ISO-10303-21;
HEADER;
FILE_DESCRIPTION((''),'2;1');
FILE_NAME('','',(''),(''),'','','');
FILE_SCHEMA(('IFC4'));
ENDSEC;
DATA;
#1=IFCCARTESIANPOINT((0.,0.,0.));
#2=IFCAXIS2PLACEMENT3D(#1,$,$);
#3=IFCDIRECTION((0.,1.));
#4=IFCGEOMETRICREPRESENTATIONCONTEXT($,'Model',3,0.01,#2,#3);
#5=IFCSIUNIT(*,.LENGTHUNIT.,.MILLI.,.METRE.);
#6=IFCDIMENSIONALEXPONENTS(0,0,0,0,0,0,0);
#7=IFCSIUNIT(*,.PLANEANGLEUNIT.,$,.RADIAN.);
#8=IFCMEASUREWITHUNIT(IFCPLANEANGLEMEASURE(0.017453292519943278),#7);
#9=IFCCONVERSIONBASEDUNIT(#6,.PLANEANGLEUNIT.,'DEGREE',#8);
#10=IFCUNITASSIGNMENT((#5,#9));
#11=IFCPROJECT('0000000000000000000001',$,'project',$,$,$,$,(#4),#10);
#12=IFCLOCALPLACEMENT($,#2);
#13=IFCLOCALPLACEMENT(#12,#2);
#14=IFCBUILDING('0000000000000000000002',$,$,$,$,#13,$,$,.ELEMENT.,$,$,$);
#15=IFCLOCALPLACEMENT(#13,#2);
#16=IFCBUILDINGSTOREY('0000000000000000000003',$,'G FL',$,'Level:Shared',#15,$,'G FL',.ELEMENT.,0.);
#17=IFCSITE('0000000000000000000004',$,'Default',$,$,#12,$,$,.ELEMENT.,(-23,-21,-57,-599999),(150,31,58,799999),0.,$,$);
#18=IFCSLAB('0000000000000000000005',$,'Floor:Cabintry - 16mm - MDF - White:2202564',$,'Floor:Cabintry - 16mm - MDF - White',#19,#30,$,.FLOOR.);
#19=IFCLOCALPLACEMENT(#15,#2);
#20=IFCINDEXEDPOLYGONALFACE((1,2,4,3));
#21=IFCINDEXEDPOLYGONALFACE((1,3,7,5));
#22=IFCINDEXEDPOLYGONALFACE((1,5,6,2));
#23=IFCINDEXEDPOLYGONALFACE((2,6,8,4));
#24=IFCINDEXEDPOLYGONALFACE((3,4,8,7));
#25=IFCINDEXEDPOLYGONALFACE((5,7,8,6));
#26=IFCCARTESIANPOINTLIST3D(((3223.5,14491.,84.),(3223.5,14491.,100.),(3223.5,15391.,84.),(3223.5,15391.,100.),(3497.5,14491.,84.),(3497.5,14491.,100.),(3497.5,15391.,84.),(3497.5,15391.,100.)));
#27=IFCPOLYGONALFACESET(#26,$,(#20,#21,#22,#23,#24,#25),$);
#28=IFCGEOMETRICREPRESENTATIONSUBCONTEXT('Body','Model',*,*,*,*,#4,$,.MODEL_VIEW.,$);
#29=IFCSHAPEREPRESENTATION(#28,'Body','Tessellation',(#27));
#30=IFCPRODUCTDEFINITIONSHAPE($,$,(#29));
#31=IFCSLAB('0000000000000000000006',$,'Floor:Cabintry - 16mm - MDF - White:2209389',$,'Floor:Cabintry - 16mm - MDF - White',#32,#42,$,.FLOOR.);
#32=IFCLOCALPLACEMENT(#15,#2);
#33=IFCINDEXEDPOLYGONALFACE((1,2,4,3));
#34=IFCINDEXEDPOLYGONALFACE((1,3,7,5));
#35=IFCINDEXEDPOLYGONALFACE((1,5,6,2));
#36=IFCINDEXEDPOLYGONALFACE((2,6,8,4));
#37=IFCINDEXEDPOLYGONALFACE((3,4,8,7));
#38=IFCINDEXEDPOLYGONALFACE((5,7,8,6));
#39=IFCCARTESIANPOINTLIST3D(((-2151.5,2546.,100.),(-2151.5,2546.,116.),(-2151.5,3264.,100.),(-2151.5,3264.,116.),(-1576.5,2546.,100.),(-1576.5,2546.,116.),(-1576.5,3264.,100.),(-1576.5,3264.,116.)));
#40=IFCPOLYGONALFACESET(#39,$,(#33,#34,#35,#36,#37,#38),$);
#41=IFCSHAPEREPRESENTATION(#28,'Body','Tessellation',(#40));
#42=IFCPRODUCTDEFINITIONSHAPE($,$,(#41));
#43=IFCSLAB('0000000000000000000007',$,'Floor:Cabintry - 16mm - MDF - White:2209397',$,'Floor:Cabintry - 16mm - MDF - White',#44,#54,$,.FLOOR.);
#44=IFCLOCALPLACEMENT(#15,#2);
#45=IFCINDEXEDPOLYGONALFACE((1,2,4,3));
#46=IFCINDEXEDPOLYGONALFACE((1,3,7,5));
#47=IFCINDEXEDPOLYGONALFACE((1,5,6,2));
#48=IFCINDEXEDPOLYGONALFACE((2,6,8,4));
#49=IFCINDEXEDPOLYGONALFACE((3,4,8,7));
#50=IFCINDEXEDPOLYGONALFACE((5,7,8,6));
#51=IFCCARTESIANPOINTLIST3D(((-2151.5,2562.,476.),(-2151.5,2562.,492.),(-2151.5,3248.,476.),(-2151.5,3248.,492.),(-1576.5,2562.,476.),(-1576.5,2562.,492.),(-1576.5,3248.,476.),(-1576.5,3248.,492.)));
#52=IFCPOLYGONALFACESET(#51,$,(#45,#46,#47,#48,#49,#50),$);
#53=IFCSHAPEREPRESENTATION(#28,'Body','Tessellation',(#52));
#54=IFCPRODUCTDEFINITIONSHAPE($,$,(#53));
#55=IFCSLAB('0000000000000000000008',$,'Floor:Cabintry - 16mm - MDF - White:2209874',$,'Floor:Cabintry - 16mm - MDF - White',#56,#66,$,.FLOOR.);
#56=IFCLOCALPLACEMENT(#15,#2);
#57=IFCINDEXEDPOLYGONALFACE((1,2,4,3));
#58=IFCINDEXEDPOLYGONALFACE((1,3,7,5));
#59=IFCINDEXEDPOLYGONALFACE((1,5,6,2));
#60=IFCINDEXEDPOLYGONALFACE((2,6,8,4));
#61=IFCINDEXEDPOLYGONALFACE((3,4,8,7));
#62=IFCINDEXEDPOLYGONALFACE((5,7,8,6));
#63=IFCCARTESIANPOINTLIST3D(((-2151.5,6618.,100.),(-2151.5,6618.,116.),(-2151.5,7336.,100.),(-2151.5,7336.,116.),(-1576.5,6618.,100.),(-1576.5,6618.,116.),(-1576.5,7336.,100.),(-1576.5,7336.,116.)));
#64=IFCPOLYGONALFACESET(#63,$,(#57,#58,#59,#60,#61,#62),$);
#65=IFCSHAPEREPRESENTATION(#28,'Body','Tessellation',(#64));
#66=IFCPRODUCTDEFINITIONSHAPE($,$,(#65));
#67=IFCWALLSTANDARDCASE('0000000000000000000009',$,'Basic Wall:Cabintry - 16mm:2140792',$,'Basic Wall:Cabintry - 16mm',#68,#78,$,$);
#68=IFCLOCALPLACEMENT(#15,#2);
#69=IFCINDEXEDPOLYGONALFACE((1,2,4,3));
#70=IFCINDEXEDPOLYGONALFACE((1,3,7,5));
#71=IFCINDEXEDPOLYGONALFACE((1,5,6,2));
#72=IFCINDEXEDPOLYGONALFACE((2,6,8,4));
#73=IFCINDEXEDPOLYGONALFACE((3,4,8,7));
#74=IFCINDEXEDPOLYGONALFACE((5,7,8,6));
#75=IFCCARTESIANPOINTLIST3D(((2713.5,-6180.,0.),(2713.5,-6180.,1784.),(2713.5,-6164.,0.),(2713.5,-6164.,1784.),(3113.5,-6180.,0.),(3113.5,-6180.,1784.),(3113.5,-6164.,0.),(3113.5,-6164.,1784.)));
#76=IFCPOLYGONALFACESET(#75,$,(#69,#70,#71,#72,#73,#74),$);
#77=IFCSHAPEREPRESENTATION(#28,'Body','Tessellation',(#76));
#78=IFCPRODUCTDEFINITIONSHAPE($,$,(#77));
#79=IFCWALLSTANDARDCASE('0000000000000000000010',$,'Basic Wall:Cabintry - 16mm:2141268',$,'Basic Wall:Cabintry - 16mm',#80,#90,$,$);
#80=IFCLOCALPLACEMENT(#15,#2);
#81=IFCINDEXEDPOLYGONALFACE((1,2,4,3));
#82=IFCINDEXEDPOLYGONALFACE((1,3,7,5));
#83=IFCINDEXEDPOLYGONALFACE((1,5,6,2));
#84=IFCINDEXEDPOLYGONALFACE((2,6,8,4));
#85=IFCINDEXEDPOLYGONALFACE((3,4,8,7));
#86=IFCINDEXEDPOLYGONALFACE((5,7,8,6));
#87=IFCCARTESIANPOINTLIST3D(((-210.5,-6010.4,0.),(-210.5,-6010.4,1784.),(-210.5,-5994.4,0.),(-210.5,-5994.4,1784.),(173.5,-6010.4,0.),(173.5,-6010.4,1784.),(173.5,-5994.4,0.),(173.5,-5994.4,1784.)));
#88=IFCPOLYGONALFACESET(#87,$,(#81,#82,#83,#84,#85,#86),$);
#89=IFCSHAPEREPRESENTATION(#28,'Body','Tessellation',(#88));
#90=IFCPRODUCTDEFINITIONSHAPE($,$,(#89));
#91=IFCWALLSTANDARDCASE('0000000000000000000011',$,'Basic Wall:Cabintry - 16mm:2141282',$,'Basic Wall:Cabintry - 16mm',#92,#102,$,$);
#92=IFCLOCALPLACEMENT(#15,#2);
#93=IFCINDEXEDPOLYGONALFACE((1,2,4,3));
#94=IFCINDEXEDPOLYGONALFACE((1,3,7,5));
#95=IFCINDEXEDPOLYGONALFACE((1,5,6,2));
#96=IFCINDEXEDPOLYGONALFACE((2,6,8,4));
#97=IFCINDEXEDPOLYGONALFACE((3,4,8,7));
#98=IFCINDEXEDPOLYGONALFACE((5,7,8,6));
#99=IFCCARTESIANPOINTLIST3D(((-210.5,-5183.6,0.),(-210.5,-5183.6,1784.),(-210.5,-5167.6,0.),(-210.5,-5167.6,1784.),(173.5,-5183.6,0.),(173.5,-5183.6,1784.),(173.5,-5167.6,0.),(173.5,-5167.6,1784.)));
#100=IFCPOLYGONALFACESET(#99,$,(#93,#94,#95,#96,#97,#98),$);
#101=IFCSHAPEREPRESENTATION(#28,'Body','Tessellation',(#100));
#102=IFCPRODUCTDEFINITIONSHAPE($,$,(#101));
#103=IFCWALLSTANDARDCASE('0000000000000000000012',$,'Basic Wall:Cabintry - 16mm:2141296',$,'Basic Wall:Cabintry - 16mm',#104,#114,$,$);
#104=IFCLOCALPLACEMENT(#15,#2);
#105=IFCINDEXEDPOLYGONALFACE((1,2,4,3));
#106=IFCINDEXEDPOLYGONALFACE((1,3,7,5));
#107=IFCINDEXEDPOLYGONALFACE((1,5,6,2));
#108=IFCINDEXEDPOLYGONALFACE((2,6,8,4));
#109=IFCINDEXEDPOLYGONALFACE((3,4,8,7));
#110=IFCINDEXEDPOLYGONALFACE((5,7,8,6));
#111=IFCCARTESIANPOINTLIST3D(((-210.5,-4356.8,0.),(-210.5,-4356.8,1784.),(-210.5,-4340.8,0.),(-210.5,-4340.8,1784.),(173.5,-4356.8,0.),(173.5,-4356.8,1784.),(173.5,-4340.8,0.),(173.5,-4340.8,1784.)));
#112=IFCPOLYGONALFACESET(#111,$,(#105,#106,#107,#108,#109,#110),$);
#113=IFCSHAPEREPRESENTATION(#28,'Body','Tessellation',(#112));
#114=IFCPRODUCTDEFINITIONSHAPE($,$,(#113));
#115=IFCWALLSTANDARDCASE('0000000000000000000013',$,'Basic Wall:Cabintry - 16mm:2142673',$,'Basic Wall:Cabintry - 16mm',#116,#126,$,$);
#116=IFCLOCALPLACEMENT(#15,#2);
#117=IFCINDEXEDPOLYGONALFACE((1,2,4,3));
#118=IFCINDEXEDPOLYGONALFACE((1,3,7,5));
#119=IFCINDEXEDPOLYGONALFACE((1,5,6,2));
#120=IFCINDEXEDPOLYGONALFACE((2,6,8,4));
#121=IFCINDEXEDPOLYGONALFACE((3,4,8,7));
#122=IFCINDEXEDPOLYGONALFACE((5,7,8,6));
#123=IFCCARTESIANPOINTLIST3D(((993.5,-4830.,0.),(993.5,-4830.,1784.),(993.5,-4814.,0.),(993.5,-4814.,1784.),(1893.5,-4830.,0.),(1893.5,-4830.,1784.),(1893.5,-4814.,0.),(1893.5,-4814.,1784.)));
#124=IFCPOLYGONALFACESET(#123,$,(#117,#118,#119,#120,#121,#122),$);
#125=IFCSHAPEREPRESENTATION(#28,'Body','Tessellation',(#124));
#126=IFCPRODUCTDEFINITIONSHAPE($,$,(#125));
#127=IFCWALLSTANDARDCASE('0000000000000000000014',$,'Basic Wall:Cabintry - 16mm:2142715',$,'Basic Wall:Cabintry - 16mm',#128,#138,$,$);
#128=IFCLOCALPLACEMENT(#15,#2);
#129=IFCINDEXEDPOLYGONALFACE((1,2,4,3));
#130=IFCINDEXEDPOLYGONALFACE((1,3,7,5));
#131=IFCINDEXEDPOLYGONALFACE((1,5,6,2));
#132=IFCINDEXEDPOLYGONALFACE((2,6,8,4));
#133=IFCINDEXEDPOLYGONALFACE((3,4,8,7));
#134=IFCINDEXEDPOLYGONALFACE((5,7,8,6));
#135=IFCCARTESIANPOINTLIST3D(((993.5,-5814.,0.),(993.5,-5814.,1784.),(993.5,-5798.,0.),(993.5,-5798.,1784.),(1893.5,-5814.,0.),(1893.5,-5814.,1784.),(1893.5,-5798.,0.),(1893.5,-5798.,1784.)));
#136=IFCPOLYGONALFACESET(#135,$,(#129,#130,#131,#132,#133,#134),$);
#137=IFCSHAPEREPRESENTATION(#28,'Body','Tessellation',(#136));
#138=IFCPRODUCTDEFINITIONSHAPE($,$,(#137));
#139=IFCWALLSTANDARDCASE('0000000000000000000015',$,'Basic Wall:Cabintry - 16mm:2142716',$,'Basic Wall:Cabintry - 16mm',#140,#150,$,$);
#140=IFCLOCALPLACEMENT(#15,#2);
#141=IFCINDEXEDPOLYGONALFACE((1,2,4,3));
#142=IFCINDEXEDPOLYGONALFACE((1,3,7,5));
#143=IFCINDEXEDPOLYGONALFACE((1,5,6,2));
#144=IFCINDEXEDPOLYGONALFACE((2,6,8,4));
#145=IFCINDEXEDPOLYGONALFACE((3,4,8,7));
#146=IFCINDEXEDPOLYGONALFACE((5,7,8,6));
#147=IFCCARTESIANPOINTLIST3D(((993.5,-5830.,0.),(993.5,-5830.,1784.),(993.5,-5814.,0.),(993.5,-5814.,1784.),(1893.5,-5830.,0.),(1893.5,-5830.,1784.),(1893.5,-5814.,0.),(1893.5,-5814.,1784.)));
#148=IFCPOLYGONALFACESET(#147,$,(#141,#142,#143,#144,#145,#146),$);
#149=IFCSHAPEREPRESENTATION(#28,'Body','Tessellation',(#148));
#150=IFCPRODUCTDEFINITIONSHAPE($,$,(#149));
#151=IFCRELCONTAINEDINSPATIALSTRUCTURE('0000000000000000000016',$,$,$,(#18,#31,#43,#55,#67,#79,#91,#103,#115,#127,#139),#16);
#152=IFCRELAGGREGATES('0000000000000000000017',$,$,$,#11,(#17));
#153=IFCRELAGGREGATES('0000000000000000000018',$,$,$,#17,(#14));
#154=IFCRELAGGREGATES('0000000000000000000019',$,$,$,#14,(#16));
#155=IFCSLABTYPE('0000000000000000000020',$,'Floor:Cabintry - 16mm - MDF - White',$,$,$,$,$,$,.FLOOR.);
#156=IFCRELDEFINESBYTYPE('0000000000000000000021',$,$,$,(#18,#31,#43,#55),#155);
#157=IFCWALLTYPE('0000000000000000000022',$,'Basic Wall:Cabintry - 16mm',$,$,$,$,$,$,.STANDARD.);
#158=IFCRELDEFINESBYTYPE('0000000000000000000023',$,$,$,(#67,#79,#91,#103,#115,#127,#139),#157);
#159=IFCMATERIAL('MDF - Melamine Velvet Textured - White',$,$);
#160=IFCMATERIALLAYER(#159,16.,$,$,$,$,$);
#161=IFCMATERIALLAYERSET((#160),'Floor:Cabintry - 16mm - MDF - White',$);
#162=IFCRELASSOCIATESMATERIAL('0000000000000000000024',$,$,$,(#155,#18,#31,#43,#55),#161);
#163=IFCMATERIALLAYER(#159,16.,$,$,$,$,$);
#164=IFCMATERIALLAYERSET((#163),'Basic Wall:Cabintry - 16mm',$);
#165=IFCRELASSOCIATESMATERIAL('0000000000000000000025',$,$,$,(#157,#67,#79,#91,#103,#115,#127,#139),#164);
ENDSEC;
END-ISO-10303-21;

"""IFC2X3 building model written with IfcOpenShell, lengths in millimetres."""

from ifc_helpers import new_model, entity, si_unit, converted_unit, direction, frame, frame_2d, origin, origin_2d_with_axis, place, context, subcontext, project, spatial, polyline, rectangle, extrude, clip, bounded_halfspace, material, layer, layer_set, layer_usage, type_object, element, save


model = new_model("IFC2X3")

# Units and contexts
model_context = context("Model", 3, precision=0.01, world=origin(), true_north=direction((0.0, 1.0)))
body_context = subcontext(model_context, "Body", "Model", "MODEL_VIEW")
ifc_project = project(units=[si_unit("LENGTHUNIT", "METRE", prefix="MILLI"), converted_unit("PLANEANGLEUNIT", "DEGREE", entity("IfcPlaneAngleMeasure", 0.017453292519943278), si_unit("PLANEANGLEUNIT", "RADIAN"), dimensions=[0, 0, 0, 0, 0, 0, 0])], contexts=[model_context])

# Site, building, storey
site_placement = place(None, origin())
site = spatial("IfcSite", under=ifc_project, at=site_placement, Name="Default", CompositionType="ELEMENT", RefLatitude=(-23, -21, -57, -599999), RefLongitude=(150, 31, 58, 799999), RefElevation=0.0)
building_placement = place(site_placement, origin())
building = spatial("IfcBuilding", under=site, at=building_placement, CompositionType="ELEMENT")
storey_placement = place(building_placement, origin())
storey = spatial("IfcBuildingStorey", under=building, at=storey_placement, Name="G FL", ObjectType="Level:Shared", LongName="G FL", CompositionType="ELEMENT", Elevation=0.0)

# Slabs
ifc_material_1 = material(Name="MDF - Melamine Velvet Textured - White")
ifc_layer_1 = layer(ifc_material_1, 16.0)
ifc_layer_set_1 = layer_set([ifc_layer_1], Name="Floor:Cabintry - 16mm - MDF - White")
slab_type_1 = type_object("IfcSlabType", Name="Floor:Cabintry - 16mm - MDF - White", PredefinedType="FLOOR", material=ifc_layer_set_1)
ifc_layer_usage_1 = layer_usage(ifc_layer_set_1, "AXIS3", "POSITIVE", 0.0)
slab_1_placement = place(storey_placement, origin())
element("IfcSlab", 1, at=slab_1_placement, inside=storey, type_object=slab_type_1, material=ifc_layer_usage_1, Name="Floor:Cabintry - 16mm - MDF - White:2202564", ObjectType="Floor:Cabintry - 16mm - MDF - White", PredefinedType="FLOOR", context=body_context, shape_type="SweptSolid", body=[
    extrude(rectangle(XDim=900.0, YDim=274.0, at=origin_2d_with_axis()), frame((3360.5, 14941.0, 100.0), z_axis=(0.0, 0.0, -1.0), x_axis=(0.0, 1.0, 0.0)), (0.0, 0.0, 1.0), 16.0),
])
ifc_layer_usage_2 = layer_usage(ifc_layer_set_1, "AXIS3", "POSITIVE", 0.0)
slab_2_placement = place(storey_placement, origin())
element("IfcSlab", 2, at=slab_2_placement, inside=storey, type_object=slab_type_1, material=ifc_layer_usage_2, Name="Floor:Cabintry - 16mm - MDF - White:2209389", ObjectType="Floor:Cabintry - 16mm - MDF - White", PredefinedType="FLOOR", context=body_context, shape_type="SweptSolid", body=[
    extrude(rectangle(XDim=718.0, YDim=575.0, at=frame_2d((0.0, 0.0), x_axis=(1.0, 0.0))), frame((-1864.0, 2905.0, 116.0), z_axis=(0.0, 0.0, -1.0), x_axis=(0.0, 1.0, 0.0)), (0.0, 0.0, 1.0), 16.0),
])
ifc_layer_usage_3 = layer_usage(ifc_layer_set_1, "AXIS3", "POSITIVE", 0.0)
slab_3_placement = place(storey_placement, origin())
element("IfcSlab", 3, at=slab_3_placement, inside=storey, type_object=slab_type_1, material=ifc_layer_usage_3, Name="Floor:Cabintry - 16mm - MDF - White:2209397", ObjectType="Floor:Cabintry - 16mm - MDF - White", PredefinedType="FLOOR", context=body_context, shape_type="SweptSolid", body=[
    extrude(rectangle(XDim=686.0, YDim=575.0, at=frame_2d((0.0, 0.0), x_axis=(1.0, 0.0))), frame((-1864.0, 2905.0, 492.0), z_axis=(0.0, 0.0, -1.0), x_axis=(0.0, 1.0, 0.0)), (0.0, 0.0, 1.0), 16.0),
])
ifc_layer_usage_4 = layer_usage(ifc_layer_set_1, "AXIS3", "POSITIVE", 0.0)
slab_4_placement = place(storey_placement, origin())
element("IfcSlab", 4, at=slab_4_placement, inside=storey, type_object=slab_type_1, material=ifc_layer_usage_4, Name="Floor:Cabintry - 16mm - MDF - White:2209874", ObjectType="Floor:Cabintry - 16mm - MDF - White", PredefinedType="FLOOR", context=body_context, shape_type="SweptSolid", body=[
    extrude(rectangle(XDim=718.0, YDim=575.0, at=frame_2d((0.0, 0.0), x_axis=(1.0, 0.0))), frame((-1864.0, 6977.0, 116.0), z_axis=(0.0, 0.0, -1.0), x_axis=(0.0, 1.0, 0.0)), (0.0, 0.0, 1.0), 16.0),
])

# Walls
ifc_layer_2 = layer(ifc_material_1, 16.0)
ifc_layer_set_2 = layer_set([ifc_layer_2], Name="Basic Wall:Cabintry - 16mm")
ifc_layer_usage_5 = layer_usage(ifc_layer_set_2, "AXIS2", "NEGATIVE", 8.0)
wall_type = type_object("IfcWallType", Name="Basic Wall:Cabintry - 16mm", PredefinedType="STANDARD", material=ifc_layer_set_2)
wall_1_placement = place(storey_placement, frame((2713.5, -6172.0, 0.0)))
element("IfcWallStandardCase", 5, at=wall_1_placement, inside=storey, type_object=wall_type, material=ifc_layer_usage_5, Name="Basic Wall:Cabintry - 16mm:2140792", ObjectType="Basic Wall:Cabintry - 16mm", context=body_context, shape_type="Clipping", body=[
    clip(extrude(rectangle(XDim=400.0, YDim=16.0, at=frame_2d((200.0, 0.0), x_axis=(-1.0, 0.0))), origin(), (0.0, 0.0, 1.0), 1784.0), bounded_halfspace(frame((0.0, -8.0, 1784.0), z_axis=(0.0, 0.0, -1.0), x_axis=(1.0, 0.0, 0.0)), True, frame((0.0, -8.0, 1784.0)), polyline([(0.0, 0.0), (384.0, 0.0), (400.0, 0.0), (400.0, 16.0), (0.0, 16.0), (0.0, 0.0)]))),
])
ifc_layer_usage_6 = layer_usage(ifc_layer_set_2, "AXIS2", "NEGATIVE", 8.0)
wall_2_placement = place(storey_placement, frame((173.5, -6002.4, 0.0), z_axis=(0.0, 0.0, 1.0), x_axis=(-1.0, 0.0, 0.0)))
element("IfcWallStandardCase", 6, at=wall_2_placement, inside=storey, type_object=wall_type, material=ifc_layer_usage_6, Name="Basic Wall:Cabintry - 16mm:2141268", ObjectType="Basic Wall:Cabintry - 16mm", context=body_context, shape_type="Clipping", body=[
    clip(extrude(rectangle(XDim=384.0, YDim=16.0, at=frame_2d((192.0, 0.0), x_axis=(-1.0, 0.0))), origin(), (0.0, 0.0, 1.0), 1784.0), bounded_halfspace(frame((0.0, -8.0, 1784.0), z_axis=(0.0, 0.0, -1.0), x_axis=(-1.0, 0.0, 0.0)), True, frame((0.0, -8.0, 1784.0)), polyline([(0.0, 0.0), (384.0, 0.0), (384.0, 16.0), (0.0, 16.0), (0.0, 0.0)]))),
])
ifc_layer_usage_7 = layer_usage(ifc_layer_set_2, "AXIS2", "NEGATIVE", 8.0)
wall_3_placement = place(storey_placement, frame((173.5, -5175.6, 0.0), z_axis=(0.0, 0.0, 1.0), x_axis=(-1.0, 0.0, 0.0)))
element("IfcWallStandardCase", 7, at=wall_3_placement, inside=storey, type_object=wall_type, material=ifc_layer_usage_7, Name="Basic Wall:Cabintry - 16mm:2141282", ObjectType="Basic Wall:Cabintry - 16mm", context=body_context, shape_type="Clipping", body=[
    clip(extrude(rectangle(XDim=384.0, YDim=16.0, at=frame_2d((192.0, 0.0), x_axis=(-1.0, 0.0))), origin(), (0.0, 0.0, 1.0), 1784.0), bounded_halfspace(frame((0.0, -8.0, 1784.0), z_axis=(0.0, 0.0, -1.0), x_axis=(-1.0, 0.0, 0.0)), True, frame((0.0, -8.0, 1784.0)), polyline([(0.0, 0.0), (384.0, 0.0), (384.0, 16.0), (0.0, 16.0), (0.0, 0.0)]))),
])
ifc_layer_usage_8 = layer_usage(ifc_layer_set_2, "AXIS2", "NEGATIVE", 8.0)
wall_4_placement = place(storey_placement, frame((173.5, -4348.8, 0.0), z_axis=(0.0, 0.0, 1.0), x_axis=(-1.0, 0.0, 0.0)))
element("IfcWallStandardCase", 8, at=wall_4_placement, inside=storey, type_object=wall_type, material=ifc_layer_usage_8, Name="Basic Wall:Cabintry - 16mm:2141296", ObjectType="Basic Wall:Cabintry - 16mm", context=body_context, shape_type="Clipping", body=[
    clip(extrude(rectangle(XDim=384.0, YDim=16.0, at=frame_2d((192.0, 0.0), x_axis=(-1.0, 0.0))), origin(), (0.0, 0.0, 1.0), 1784.0), bounded_halfspace(frame((0.0, -8.0, 1784.0), z_axis=(0.0, 0.0, -1.0), x_axis=(-1.0, 0.0, 0.0)), True, frame((0.0, -8.0, 1784.0)), polyline([(0.0, 0.0), (384.0, 0.0), (384.0, 16.0), (0.0, 16.0), (0.0, 0.0)]))),
])
ifc_layer_usage_9 = layer_usage(ifc_layer_set_2, "AXIS2", "NEGATIVE", 8.0)
wall_5_placement = place(storey_placement, frame((993.5, -4822.0, 0.0)))
element("IfcWallStandardCase", 9, at=wall_5_placement, inside=storey, type_object=wall_type, material=ifc_layer_usage_9, Name="Basic Wall:Cabintry - 16mm:2142673", ObjectType="Basic Wall:Cabintry - 16mm", context=body_context, shape_type="SweptSolid", body=[
    extrude(rectangle(XDim=900.0, YDim=16.0, at=frame_2d((450.0, 0.0), x_axis=(-1.0, 0.0))), origin(), (0.0, 0.0, 1.0), 1784.0),
])
ifc_layer_usage_10 = layer_usage(ifc_layer_set_2, "AXIS2", "NEGATIVE", 8.0)
wall_6_placement = place(storey_placement, frame((993.5, -5806.0, 0.0)))
element("IfcWallStandardCase", 10, at=wall_6_placement, inside=storey, type_object=wall_type, material=ifc_layer_usage_10, Name="Basic Wall:Cabintry - 16mm:2142715", ObjectType="Basic Wall:Cabintry - 16mm", context=body_context, shape_type="SweptSolid", body=[
    extrude(rectangle(XDim=900.0, YDim=16.0, at=frame_2d((450.0, 0.0), x_axis=(-1.0, 0.0))), origin(), (0.0, 0.0, 1.0), 1784.0),
])
ifc_layer_usage_11 = layer_usage(ifc_layer_set_2, "AXIS2", "POSITIVE", -8.0)
wall_7_placement = place(storey_placement, frame((993.5, -5822.0, 0.0)))
element("IfcWallStandardCase", 11, at=wall_7_placement, inside=storey, type_object=wall_type, material=ifc_layer_usage_11, Name="Basic Wall:Cabintry - 16mm:2142716", ObjectType="Basic Wall:Cabintry - 16mm", context=body_context, shape_type="SweptSolid", body=[
    extrude(rectangle(XDim=900.0, YDim=16.0, at=frame_2d((450.0, 0.0), x_axis=(-1.0, 0.0))), origin(), (0.0, 0.0, 1.0), 1784.0),
])

save(model, "model.ifc")
